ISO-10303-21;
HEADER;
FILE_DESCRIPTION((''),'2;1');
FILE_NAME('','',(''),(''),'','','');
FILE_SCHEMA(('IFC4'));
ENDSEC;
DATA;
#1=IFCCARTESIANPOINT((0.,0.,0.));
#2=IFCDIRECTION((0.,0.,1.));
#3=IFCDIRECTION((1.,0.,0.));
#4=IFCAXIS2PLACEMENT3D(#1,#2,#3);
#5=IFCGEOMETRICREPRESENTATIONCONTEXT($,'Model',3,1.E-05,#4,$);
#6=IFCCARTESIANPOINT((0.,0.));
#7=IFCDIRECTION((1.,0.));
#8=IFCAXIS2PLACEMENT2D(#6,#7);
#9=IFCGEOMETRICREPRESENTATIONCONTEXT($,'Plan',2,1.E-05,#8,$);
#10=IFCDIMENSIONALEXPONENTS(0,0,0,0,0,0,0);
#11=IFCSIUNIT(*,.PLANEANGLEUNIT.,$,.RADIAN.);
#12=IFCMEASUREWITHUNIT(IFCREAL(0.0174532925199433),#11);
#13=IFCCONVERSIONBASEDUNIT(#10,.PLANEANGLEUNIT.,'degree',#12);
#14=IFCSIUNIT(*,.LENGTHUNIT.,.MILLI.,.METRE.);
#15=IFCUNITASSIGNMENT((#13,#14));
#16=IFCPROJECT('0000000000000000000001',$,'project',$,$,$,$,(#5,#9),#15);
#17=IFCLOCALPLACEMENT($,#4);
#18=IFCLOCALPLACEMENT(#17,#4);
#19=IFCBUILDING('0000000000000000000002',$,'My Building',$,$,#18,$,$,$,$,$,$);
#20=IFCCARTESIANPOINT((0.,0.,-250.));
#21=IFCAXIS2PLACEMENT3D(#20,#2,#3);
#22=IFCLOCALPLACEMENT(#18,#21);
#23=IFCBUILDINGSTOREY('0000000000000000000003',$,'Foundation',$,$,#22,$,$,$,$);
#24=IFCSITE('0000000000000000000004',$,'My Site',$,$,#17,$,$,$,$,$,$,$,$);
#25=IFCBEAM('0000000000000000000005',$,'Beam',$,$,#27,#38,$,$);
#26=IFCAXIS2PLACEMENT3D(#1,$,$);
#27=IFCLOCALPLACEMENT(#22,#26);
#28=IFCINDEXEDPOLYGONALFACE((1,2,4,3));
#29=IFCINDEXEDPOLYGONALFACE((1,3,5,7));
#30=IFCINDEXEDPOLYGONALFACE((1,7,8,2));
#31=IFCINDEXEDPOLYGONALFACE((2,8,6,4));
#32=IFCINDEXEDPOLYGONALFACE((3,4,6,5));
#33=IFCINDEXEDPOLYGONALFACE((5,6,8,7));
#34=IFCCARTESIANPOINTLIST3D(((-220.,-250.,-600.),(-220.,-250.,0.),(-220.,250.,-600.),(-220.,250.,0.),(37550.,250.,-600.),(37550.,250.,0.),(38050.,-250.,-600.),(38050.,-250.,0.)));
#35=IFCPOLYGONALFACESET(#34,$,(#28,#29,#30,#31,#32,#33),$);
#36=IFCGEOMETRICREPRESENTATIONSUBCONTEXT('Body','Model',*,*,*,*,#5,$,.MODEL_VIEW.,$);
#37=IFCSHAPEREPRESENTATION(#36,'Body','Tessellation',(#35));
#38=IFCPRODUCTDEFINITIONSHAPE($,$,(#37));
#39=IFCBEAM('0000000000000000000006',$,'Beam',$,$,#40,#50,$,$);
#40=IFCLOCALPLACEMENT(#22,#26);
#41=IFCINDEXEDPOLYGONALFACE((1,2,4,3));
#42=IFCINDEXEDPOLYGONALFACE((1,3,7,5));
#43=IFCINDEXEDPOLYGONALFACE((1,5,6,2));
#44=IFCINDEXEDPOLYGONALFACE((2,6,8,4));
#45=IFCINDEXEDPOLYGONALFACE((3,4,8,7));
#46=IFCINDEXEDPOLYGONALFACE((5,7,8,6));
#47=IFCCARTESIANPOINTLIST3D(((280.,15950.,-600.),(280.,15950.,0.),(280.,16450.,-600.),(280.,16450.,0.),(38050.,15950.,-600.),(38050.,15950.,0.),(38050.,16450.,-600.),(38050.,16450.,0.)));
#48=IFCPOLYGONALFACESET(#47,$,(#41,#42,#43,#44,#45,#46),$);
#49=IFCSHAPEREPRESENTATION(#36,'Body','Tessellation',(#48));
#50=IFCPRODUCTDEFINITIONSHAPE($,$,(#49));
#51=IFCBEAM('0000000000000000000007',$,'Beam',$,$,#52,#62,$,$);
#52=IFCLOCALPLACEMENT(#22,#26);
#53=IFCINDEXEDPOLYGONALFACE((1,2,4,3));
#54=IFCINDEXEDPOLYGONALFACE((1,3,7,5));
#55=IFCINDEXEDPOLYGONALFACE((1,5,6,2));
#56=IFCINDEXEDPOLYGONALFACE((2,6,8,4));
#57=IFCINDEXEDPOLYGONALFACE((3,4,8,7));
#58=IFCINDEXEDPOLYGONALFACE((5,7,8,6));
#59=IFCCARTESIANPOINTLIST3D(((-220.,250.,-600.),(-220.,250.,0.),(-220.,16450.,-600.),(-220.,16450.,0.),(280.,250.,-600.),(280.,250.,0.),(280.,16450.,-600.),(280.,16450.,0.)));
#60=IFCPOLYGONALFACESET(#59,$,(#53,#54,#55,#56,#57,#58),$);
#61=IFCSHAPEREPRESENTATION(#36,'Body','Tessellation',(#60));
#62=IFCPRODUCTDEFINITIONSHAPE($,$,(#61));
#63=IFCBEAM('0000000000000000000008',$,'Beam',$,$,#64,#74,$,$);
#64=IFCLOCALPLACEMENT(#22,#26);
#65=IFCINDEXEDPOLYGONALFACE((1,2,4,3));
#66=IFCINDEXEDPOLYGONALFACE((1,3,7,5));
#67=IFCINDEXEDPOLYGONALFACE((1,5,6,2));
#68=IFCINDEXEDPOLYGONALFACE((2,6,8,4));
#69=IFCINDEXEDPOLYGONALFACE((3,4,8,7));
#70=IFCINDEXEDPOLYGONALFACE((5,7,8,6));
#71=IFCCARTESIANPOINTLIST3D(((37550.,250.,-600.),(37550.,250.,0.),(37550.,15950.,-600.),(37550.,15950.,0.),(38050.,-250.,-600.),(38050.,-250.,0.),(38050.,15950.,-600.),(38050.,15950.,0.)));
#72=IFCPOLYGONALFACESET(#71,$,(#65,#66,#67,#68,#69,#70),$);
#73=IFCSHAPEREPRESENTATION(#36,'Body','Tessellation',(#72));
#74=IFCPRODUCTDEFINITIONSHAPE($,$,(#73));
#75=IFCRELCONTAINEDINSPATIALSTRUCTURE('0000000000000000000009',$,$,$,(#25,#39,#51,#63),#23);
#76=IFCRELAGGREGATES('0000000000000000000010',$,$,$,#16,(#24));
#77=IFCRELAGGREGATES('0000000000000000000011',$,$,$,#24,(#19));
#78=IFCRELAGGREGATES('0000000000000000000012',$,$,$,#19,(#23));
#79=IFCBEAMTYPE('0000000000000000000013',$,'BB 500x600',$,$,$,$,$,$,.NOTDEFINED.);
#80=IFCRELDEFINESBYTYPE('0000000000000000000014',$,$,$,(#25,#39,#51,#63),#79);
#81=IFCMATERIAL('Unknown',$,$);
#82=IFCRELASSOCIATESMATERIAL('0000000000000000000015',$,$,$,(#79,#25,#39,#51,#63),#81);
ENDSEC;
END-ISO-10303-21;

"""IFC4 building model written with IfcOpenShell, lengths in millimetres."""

from ifc_helpers import new_model, entity, si_unit, converted_unit, frame, origin_with_axes, origin_2d_with_axis, place, context, subcontext, project, spatial, rectangle, extrude, clip, halfspace, material, material_profile, profile_set, profile_usage, type_object, element, save


model = new_model("IFC4")

# Units and contexts
model_context = context("Model", 3, precision=1e-05, world=origin_with_axes())
plan_context = context("Plan", 2, precision=1e-05, world=origin_2d_with_axis())
body_context = subcontext(model_context, "Body", "Model", "MODEL_VIEW")
ifc_project = project(units=[converted_unit("PLANEANGLEUNIT", "degree", entity("IfcReal", 0.0174532925199433), si_unit("PLANEANGLEUNIT", "RADIAN"), dimensions=[0, 0, 0, 0, 0, 0, 0]), si_unit("LENGTHUNIT", "METRE", prefix="MILLI")], contexts=[model_context, plan_context])

# Site, building, storey
site_placement = place(None, origin_with_axes())
site = spatial("IfcSite", under=ifc_project, at=site_placement, Name="My Site")
building_placement = place(site_placement, origin_with_axes())
building = spatial("IfcBuilding", under=site, at=building_placement, Name="My Building")
storey_placement = place(building_placement, frame((0.0, 0.0, -250.0), z_axis=(0.0, 0.0, 1.0), x_axis=(1.0, 0.0, 0.0)))
storey = spatial("IfcBuildingStorey", under=building, at=storey_placement, Name="Foundation")

# Beams
ifc_material = material(Name="Unknown")
ifc_material_profile = material_profile(ifc_material, rectangle(XDim=500.0, YDim=600.0))
ifc_profile_set = profile_set([ifc_material_profile])
ifc_profile_usage_1 = profile_usage(ifc_profile_set, cardinal=8)
beam_type = type_object("IfcBeamType", Name="BB 500x600", PredefinedType="NOTDEFINED", material=ifc_profile_set)
beam_1_placement = place(storey_placement, frame((-220.0, 0.0, 0.0), z_axis=(1.0, 0.0, 0.0), x_axis=(0.0, 1.0, 0.0)))
element("IfcBeam", 1, at=beam_1_placement, inside=storey, type_object=beam_type, material=ifc_profile_usage_1, Name="Beam", context=body_context, shape_type="Clipping", body=[
    clip(extrude(rectangle(XDim=500.0, YDim=600.0), frame((0.0, -300.0, 0.0), z_axis=(0.0, 0.0, 1.0), x_axis=(1.0, 0.0, 0.0)), (0.0, 0.0, 1.0), 38270.0), halfspace(frame((-250.0, 250.0, 38270.0), z_axis=(0.707107, 0.0, 0.707107), x_axis=(0.707107, 0.0, -0.707107)), False)),
])
ifc_profile_usage_2 = profile_usage(ifc_profile_set, cardinal=8)
beam_2_placement = place(storey_placement, frame((280.0, 16200.0, 0.0), z_axis=(1.0, 0.0, 0.0), x_axis=(0.0, 1.0, 0.0)))
element("IfcBeam", 2, at=beam_2_placement, inside=storey, type_object=beam_type, material=ifc_profile_usage_2, Name="Beam", context=body_context, shape_type="SweptSolid", body=[
    extrude(rectangle(XDim=500.0, YDim=600.0), frame((0.0, -300.0, 0.0), z_axis=(0.0, 0.0, 1.0), x_axis=(1.0, 0.0, 0.0)), (0.0, 0.0, 1.0), 37770.0),
])
ifc_profile_usage_3 = profile_usage(ifc_profile_set, cardinal=8)
beam_3_placement = place(storey_placement, frame((30.0, 250.0, 0.0), z_axis=(0.0, 1.0, 0.0), x_axis=(-1.0, 0.0, 0.0)))
element("IfcBeam", 3, at=beam_3_placement, inside=storey, type_object=beam_type, material=ifc_profile_usage_3, Name="Beam", context=body_context, shape_type="SweptSolid", body=[
    extrude(rectangle(XDim=500.0, YDim=600.0), frame((0.0, -300.0, 0.0), z_axis=(0.0, 0.0, 1.0), x_axis=(1.0, 0.0, 0.0)), (0.0, 0.0, 1.0), 16200.0),
])
ifc_profile_usage_4 = profile_usage(ifc_profile_set, cardinal=8)
beam_4_placement = place(storey_placement, frame((37800.0, -250.0, 0.0), z_axis=(0.0, 1.0, 0.0), x_axis=(-1.0, 0.0, 0.0)))
element("IfcBeam", 4, at=beam_4_placement, inside=storey, type_object=beam_type, material=ifc_profile_usage_4, Name="Beam", context=body_context, shape_type="Clipping", body=[
    clip(extrude(rectangle(XDim=500.0, YDim=600.0), frame((0.0, -300.0, 0.0), z_axis=(0.0, 0.0, 1.0), x_axis=(1.0, 0.0, 0.0)), (0.0, 0.0, 1.0), 16200.0), halfspace(frame((-250.0, 250.0, 0.0), z_axis=(0.707107, 0.0, -0.707107), x_axis=(0.707107, 0.0, 0.707107)), False)),
])

save(model, "model.ifc")
